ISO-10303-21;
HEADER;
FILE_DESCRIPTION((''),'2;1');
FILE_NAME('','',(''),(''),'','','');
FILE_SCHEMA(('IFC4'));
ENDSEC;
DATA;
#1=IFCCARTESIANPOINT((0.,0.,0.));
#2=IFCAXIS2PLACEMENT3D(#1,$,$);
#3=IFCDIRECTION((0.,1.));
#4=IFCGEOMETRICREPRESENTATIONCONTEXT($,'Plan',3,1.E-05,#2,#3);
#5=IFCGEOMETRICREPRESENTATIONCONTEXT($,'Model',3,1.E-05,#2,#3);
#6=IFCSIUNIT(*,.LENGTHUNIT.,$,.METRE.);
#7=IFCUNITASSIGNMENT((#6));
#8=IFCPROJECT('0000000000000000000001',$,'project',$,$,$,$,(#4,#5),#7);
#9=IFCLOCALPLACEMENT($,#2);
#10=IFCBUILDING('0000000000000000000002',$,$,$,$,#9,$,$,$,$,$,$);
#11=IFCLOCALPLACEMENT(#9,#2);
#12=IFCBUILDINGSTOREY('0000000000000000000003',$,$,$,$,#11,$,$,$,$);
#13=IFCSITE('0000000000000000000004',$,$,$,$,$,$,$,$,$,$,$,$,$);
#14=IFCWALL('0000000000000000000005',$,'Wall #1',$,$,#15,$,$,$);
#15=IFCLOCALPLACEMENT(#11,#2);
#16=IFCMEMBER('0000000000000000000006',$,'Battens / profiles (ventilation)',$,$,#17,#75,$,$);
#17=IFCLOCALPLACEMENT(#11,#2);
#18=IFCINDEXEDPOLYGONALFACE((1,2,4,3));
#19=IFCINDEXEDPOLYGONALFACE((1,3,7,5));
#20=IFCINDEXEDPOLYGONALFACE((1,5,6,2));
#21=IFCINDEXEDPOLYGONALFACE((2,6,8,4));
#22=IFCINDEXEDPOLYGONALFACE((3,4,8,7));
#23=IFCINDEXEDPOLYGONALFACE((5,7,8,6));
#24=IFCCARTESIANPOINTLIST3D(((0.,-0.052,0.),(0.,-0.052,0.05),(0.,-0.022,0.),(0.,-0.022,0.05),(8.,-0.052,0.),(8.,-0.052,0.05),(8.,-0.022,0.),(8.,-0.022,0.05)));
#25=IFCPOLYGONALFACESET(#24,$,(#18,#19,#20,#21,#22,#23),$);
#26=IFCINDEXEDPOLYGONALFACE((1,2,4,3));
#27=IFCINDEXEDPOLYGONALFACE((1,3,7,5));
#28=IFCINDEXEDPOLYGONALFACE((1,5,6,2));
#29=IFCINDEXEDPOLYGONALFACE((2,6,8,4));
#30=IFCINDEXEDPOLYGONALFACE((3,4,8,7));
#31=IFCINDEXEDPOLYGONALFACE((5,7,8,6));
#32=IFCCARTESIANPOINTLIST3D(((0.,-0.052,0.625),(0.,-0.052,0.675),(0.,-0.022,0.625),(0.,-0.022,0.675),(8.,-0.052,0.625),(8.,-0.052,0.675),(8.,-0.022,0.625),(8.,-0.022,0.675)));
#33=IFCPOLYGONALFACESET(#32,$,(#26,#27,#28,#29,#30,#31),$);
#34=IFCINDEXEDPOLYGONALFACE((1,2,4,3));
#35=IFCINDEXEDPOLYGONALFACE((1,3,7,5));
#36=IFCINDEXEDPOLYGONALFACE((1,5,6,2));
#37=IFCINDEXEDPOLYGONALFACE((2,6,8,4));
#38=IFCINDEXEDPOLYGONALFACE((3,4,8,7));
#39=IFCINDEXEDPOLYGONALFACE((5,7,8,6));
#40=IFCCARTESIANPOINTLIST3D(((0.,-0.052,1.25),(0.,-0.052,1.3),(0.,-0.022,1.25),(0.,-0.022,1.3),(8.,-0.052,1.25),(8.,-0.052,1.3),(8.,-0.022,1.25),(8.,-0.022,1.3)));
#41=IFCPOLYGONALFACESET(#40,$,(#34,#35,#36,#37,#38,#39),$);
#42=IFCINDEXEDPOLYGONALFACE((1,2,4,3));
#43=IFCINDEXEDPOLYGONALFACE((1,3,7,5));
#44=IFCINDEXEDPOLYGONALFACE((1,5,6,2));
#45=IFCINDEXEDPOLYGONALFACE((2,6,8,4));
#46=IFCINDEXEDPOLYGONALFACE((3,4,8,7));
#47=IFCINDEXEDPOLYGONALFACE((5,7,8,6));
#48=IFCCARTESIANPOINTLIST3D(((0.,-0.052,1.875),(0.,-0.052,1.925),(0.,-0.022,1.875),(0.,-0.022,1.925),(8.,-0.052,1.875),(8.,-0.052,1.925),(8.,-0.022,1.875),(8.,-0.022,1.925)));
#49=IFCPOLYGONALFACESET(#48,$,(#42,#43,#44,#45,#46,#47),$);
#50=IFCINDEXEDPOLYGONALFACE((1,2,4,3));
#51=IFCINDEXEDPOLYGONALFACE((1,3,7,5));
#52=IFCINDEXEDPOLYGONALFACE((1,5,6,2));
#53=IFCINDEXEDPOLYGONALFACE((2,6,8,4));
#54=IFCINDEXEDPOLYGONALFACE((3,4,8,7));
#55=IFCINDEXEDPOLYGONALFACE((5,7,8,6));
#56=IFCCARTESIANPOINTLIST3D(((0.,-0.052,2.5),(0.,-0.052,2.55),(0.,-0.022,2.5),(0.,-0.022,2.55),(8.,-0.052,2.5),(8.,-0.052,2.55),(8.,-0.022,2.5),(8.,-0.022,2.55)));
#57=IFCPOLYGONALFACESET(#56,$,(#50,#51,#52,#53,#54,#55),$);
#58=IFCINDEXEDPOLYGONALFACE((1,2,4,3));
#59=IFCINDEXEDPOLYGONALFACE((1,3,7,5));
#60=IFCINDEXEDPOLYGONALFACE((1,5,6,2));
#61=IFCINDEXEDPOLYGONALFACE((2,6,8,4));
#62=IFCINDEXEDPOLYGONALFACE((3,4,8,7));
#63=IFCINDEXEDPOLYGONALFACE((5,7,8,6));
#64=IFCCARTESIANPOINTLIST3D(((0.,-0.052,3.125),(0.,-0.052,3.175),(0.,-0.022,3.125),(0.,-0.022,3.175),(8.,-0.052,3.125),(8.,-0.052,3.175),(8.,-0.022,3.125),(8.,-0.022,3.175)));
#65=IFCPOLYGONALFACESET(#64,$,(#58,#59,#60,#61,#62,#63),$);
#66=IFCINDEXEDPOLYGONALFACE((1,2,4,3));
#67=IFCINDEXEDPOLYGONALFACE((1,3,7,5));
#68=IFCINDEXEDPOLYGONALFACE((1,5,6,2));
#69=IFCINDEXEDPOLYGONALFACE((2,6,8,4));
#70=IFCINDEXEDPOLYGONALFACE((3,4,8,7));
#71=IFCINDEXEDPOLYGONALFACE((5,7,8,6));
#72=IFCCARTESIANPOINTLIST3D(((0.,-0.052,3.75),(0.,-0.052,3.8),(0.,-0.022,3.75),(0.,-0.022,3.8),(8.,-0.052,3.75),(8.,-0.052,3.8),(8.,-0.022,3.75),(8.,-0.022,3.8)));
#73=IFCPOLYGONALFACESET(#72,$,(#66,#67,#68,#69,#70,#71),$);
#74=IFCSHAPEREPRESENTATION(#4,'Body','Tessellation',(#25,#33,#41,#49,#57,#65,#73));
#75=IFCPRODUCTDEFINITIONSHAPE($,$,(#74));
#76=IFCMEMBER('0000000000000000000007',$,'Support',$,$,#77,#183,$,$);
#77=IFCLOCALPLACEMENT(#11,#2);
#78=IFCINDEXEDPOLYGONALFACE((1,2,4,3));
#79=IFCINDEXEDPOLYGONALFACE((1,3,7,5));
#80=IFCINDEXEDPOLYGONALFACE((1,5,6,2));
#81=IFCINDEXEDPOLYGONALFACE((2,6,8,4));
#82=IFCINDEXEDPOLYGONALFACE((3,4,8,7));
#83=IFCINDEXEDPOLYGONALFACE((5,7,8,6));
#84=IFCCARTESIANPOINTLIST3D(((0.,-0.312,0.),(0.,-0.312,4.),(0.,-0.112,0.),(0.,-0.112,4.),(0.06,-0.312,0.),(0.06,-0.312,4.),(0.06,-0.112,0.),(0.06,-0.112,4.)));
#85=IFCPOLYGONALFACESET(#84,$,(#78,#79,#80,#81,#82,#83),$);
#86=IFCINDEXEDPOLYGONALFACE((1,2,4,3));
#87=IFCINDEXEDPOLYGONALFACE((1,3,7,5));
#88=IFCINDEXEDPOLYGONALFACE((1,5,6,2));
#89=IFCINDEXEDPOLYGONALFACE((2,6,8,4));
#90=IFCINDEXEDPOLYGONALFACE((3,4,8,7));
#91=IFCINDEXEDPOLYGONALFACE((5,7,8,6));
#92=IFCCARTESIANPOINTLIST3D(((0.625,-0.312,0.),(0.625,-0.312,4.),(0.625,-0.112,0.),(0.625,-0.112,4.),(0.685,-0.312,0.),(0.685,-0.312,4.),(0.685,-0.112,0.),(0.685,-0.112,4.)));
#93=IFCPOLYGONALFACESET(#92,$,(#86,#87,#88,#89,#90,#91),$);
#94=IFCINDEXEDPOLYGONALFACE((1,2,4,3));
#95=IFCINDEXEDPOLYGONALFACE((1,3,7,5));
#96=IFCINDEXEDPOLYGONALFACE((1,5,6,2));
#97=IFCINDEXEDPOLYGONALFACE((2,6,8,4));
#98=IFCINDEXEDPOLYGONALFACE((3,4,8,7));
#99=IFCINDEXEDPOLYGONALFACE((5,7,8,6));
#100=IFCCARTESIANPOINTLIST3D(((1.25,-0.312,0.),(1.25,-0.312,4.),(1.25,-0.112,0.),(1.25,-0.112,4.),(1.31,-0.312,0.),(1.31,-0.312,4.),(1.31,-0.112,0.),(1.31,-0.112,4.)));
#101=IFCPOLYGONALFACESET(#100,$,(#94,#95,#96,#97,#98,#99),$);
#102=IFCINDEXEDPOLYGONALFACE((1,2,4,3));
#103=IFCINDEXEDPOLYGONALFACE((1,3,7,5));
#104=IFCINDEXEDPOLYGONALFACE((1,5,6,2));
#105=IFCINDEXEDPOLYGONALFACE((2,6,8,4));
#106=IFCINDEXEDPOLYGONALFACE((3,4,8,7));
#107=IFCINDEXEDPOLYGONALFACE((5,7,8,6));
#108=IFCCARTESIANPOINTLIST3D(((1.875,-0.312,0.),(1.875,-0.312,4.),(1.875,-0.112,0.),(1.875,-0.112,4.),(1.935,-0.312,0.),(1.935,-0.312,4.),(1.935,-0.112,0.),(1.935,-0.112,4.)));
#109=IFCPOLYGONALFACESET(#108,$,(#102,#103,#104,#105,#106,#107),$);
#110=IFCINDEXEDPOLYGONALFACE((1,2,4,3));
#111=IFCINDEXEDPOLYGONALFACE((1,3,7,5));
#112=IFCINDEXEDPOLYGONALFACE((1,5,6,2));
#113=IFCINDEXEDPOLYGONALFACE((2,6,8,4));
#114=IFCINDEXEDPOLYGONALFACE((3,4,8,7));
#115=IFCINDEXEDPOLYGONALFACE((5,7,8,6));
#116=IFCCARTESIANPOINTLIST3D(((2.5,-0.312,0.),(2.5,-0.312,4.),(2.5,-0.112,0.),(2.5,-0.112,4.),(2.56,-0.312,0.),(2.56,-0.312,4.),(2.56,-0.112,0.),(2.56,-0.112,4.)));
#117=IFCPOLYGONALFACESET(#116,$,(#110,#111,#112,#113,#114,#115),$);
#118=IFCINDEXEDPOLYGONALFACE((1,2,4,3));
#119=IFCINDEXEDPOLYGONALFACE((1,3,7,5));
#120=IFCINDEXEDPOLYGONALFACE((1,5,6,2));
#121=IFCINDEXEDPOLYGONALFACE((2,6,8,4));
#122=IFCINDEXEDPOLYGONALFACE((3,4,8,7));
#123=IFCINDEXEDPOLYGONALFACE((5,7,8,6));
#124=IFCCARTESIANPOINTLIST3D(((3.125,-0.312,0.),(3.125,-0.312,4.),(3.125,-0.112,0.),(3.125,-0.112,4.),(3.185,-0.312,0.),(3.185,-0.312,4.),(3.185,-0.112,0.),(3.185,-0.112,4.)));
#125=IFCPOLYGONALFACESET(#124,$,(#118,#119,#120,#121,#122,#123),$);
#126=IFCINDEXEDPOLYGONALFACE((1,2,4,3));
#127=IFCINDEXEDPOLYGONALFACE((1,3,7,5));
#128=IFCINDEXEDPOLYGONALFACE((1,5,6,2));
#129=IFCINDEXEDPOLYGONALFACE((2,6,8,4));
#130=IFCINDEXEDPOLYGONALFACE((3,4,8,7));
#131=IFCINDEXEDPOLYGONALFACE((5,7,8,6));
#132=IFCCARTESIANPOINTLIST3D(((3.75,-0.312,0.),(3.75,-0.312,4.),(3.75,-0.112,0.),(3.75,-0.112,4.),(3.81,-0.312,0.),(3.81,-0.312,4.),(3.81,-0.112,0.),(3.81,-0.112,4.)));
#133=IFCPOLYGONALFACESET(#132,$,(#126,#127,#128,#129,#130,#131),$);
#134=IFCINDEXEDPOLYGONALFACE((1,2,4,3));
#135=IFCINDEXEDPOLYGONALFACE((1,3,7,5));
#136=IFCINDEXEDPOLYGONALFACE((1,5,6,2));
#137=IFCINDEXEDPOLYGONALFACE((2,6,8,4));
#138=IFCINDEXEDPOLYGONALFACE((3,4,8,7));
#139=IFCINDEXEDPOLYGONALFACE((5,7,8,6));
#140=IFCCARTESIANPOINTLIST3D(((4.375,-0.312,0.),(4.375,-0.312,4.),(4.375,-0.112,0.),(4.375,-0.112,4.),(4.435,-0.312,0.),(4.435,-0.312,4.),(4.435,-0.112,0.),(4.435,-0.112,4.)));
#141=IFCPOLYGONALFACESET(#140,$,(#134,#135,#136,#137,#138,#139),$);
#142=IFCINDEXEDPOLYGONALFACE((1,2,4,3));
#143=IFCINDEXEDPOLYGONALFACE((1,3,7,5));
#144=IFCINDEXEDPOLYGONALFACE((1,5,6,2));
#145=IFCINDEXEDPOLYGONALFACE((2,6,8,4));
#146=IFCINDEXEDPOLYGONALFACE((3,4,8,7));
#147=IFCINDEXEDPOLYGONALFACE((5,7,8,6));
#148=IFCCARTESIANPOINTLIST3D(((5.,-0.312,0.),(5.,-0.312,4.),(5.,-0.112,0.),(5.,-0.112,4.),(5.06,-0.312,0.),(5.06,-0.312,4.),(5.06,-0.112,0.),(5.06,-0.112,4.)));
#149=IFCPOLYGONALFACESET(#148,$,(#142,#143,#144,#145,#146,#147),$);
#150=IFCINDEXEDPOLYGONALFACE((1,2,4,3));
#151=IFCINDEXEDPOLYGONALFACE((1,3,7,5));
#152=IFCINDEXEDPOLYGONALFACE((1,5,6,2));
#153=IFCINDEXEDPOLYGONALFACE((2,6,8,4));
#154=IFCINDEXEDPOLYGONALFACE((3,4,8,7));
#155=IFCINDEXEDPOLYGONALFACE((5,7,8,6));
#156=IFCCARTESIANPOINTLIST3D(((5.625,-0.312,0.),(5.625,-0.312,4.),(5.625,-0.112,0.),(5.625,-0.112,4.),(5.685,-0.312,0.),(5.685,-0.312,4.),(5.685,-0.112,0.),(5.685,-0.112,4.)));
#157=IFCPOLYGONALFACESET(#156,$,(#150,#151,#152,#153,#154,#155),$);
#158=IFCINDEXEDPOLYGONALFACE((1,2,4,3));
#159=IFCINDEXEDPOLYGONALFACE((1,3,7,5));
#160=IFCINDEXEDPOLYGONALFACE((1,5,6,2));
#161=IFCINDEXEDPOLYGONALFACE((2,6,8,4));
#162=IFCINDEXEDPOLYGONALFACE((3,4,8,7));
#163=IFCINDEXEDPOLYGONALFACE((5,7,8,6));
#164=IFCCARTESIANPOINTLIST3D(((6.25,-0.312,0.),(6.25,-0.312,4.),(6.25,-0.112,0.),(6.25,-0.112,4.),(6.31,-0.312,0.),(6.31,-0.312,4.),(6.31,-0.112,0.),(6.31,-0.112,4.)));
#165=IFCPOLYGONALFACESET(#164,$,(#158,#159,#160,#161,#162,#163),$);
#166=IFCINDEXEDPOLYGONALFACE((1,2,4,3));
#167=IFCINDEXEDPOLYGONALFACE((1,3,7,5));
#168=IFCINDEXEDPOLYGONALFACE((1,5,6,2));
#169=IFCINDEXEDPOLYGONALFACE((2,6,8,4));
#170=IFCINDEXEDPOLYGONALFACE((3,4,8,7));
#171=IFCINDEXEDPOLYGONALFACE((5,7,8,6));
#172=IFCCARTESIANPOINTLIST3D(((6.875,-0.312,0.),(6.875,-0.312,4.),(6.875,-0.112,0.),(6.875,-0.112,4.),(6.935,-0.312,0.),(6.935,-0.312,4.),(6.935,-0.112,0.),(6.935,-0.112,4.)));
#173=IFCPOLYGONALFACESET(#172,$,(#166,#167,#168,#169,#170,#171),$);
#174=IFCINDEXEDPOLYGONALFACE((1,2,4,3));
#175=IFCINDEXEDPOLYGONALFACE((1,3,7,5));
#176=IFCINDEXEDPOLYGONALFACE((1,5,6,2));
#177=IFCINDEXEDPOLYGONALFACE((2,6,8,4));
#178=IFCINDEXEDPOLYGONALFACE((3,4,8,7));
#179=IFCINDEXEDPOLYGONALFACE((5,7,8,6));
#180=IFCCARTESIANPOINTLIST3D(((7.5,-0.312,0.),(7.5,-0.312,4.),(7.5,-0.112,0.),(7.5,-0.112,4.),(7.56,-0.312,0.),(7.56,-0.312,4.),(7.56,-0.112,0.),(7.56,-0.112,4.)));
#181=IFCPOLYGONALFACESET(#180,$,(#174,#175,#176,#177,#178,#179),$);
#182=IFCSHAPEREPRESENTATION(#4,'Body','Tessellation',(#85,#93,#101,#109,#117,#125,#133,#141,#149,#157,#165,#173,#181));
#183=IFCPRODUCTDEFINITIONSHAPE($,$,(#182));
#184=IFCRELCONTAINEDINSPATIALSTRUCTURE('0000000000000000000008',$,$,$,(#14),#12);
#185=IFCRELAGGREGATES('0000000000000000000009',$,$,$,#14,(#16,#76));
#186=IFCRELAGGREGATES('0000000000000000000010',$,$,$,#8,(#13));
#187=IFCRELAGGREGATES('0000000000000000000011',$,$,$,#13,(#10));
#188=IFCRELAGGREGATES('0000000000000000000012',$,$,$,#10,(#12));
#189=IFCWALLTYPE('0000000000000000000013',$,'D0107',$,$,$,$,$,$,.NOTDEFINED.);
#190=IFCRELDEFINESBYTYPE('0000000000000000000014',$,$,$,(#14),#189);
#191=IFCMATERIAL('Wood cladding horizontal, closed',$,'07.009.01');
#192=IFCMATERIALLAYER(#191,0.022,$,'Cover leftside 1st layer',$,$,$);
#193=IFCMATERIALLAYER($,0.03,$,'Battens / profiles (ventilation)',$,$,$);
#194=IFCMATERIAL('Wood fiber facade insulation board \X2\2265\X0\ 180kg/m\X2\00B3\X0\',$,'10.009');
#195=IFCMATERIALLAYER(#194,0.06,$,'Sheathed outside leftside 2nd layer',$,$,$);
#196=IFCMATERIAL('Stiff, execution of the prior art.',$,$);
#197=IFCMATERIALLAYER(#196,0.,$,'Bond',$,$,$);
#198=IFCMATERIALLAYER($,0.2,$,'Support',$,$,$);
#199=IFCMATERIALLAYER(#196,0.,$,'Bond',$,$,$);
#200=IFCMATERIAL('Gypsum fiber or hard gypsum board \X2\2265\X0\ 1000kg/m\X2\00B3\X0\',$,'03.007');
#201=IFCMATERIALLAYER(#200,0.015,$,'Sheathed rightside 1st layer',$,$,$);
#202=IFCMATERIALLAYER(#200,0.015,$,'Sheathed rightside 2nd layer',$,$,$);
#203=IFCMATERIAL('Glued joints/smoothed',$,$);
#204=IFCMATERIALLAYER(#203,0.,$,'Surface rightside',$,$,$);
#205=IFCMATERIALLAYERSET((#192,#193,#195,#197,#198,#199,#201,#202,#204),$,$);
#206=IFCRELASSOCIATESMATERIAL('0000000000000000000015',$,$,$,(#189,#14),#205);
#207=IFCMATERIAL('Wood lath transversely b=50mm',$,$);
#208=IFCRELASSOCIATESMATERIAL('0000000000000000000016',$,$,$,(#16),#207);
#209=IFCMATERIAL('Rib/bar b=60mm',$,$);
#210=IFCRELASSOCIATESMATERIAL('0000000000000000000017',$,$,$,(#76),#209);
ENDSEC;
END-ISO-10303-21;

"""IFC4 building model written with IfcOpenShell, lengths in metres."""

from ifc_helpers import new_model, si_unit, direction, frame, frame_2d, origin, place, context, project, spatial, rectangle, extrude, material, layer, layer_set, type_object, element, aggregate, save


model = new_model("IFC4")

# Units and contexts
plan_context = context("Plan", 3, precision=1e-05, world=origin(), true_north=direction((0.0, 1.0)))
model_context = context("Model", 3, precision=1e-05, world=origin(), true_north=direction((0.0, 1.0)))
ifc_project = project(units=[si_unit("LENGTHUNIT", "METRE")], contexts=[plan_context, model_context])

# Site, building, storey
site = spatial("IfcSite", under=ifc_project)
building_placement = place(None, origin())
building = spatial("IfcBuilding", under=site, at=building_placement)
storey_placement = place(building_placement, origin())
storey = spatial("IfcBuildingStorey", under=building, at=storey_placement)

# Wall, members
ifc_material_1 = material(Name="Wood cladding horizontal, closed", Category="07.009.01")
ifc_layer_1 = layer(ifc_material_1, 0.022, Name="Cover leftside 1st layer")
ifc_layer_2 = layer(None, 0.03, Name="Battens / profiles (ventilation)")
ifc_material_2 = material(Name="Wood fiber facade insulation board ≥ 180kg/m³", Category="10.009")
ifc_layer_3 = layer(ifc_material_2, 0.06, Name="Sheathed outside leftside 2nd layer")
ifc_material_3 = material(Name="Stiff, execution of the prior art.")
ifc_layer_4 = layer(ifc_material_3, 0.0, Name="Bond")
ifc_layer_5 = layer(None, 0.2, Name="Support")
ifc_layer_6 = layer(ifc_material_3, 0.0, Name="Bond")
ifc_material_4 = material(Name="Gypsum fiber or hard gypsum board ≥ 1000kg/m³", Category="03.007")
ifc_layer_7 = layer(ifc_material_4, 0.015, Name="Sheathed rightside 1st layer")
ifc_layer_8 = layer(ifc_material_4, 0.015, Name="Sheathed rightside 2nd layer")
ifc_material_5 = material(Name="Glued joints/smoothed")
ifc_layer_9 = layer(ifc_material_5, 0.0, Name="Surface rightside")
ifc_layer_set = layer_set([ifc_layer_1, ifc_layer_2, ifc_layer_3, ifc_layer_4, ifc_layer_5, ifc_layer_6, ifc_layer_7, ifc_layer_8, ifc_layer_9])
wall_type = type_object("IfcWallType", Name="D0107", PredefinedType="NOTDEFINED", material=ifc_layer_set)
wall_placement = place(None, frame((0.0, 0.0, 0.0), z_axis=(0.0, -1.0, 0.0), x_axis=(1.0, 0.0, 0.0)))
wall = element("IfcWall", 1, at=wall_placement, inside=storey, type_object=wall_type, material=ifc_layer_set, Name="Wall #1")
ifc_material_6 = material(Name="Wood lath transversely b=50mm")
member_1_placement = place(wall_placement, origin())
member_1 = element("IfcMember", 2, at=member_1_placement, material=ifc_material_6, Name="Battens / profiles (ventilation)", context=plan_context, shape_type="SweptSolid", body=[
    extrude(rectangle(XDim=0.05, YDim=0.03, at=frame_2d((0.025, 0.015), x_axis=(1.0, 0.0))), frame((0.0, 0.0, 0.022), z_axis=(1.0, 0.0, 0.0), x_axis=(0.0, 1.0, 0.0)), (0.0, 0.0, 1.0), 8.0),
    extrude(rectangle(XDim=0.05, YDim=0.03, at=frame_2d((0.025, 0.015), x_axis=(1.0, 0.0))), frame((0.0, 0.625, 0.022), z_axis=(1.0, 0.0, 0.0), x_axis=(0.0, 1.0, 0.0)), (0.0, 0.0, 1.0), 8.0),
    extrude(rectangle(XDim=0.05, YDim=0.03, at=frame_2d((0.025, 0.015), x_axis=(1.0, 0.0))), frame((0.0, 1.25, 0.022), z_axis=(1.0, 0.0, 0.0), x_axis=(0.0, 1.0, 0.0)), (0.0, 0.0, 1.0), 8.0),
    extrude(rectangle(XDim=0.05, YDim=0.03, at=frame_2d((0.025, 0.015), x_axis=(1.0, 0.0))), frame((0.0, 1.875, 0.022), z_axis=(1.0, 0.0, 0.0), x_axis=(0.0, 1.0, 0.0)), (0.0, 0.0, 1.0), 8.0),
    extrude(rectangle(XDim=0.05, YDim=0.03, at=frame_2d((0.025, 0.015), x_axis=(1.0, 0.0))), frame((0.0, 2.5, 0.022), z_axis=(1.0, 0.0, 0.0), x_axis=(0.0, 1.0, 0.0)), (0.0, 0.0, 1.0), 8.0),
    extrude(rectangle(XDim=0.05, YDim=0.03, at=frame_2d((0.025, 0.015), x_axis=(1.0, 0.0))), frame((0.0, 3.125, 0.022), z_axis=(1.0, 0.0, 0.0), x_axis=(0.0, 1.0, 0.0)), (0.0, 0.0, 1.0), 8.0),
    extrude(rectangle(XDim=0.05, YDim=0.03, at=frame_2d((0.025, 0.015), x_axis=(1.0, 0.0))), frame((0.0, 3.75, 0.022), z_axis=(1.0, 0.0, 0.0), x_axis=(0.0, 1.0, 0.0)), (0.0, 0.0, 1.0), 8.0),
])
ifc_material_7 = material(Name="Rib/bar b=60mm")
member_2_placement = place(wall_placement, origin())
member_2 = element("IfcMember", 3, at=member_2_placement, material=ifc_material_7, Name="Support", context=plan_context, shape_type="SweptSolid", body=[
    extrude(rectangle(XDim=0.06, YDim=0.2, at=frame_2d((0.03, 0.1), x_axis=(1.0, 0.0))), frame((0.0, 4.0, 0.112), z_axis=(0.0, -1.0, 0.0), x_axis=(1.0, 0.0, 0.0)), (0.0, 0.0, 1.0), 4.0),
    extrude(rectangle(XDim=0.06, YDim=0.2, at=frame_2d((0.03, 0.1), x_axis=(1.0, 0.0))), frame((0.625, 4.0, 0.112), z_axis=(0.0, -1.0, 0.0), x_axis=(1.0, 0.0, 0.0)), (0.0, 0.0, 1.0), 4.0),
    extrude(rectangle(XDim=0.06, YDim=0.2, at=frame_2d((0.03, 0.1), x_axis=(1.0, 0.0))), frame((1.25, 4.0, 0.112), z_axis=(0.0, -1.0, 0.0), x_axis=(1.0, 0.0, 0.0)), (0.0, 0.0, 1.0), 4.0),
    extrude(rectangle(XDim=0.06, YDim=0.2, at=frame_2d((0.03, 0.1), x_axis=(1.0, 0.0))), frame((1.875, 4.0, 0.112), z_axis=(0.0, -1.0, 0.0), x_axis=(1.0, 0.0, 0.0)), (0.0, 0.0, 1.0), 4.0),
    extrude(rectangle(XDim=0.06, YDim=0.2, at=frame_2d((0.03, 0.1), x_axis=(1.0, 0.0))), frame((2.5, 4.0, 0.112), z_axis=(0.0, -1.0, 0.0), x_axis=(1.0, 0.0, 0.0)), (0.0, 0.0, 1.0), 4.0),
    extrude(rectangle(XDim=0.06, YDim=0.2, at=frame_2d((0.03, 0.1), x_axis=(1.0, 0.0))), frame((3.125, 4.0, 0.112), z_axis=(0.0, -1.0, 0.0), x_axis=(1.0, 0.0, 0.0)), (0.0, 0.0, 1.0), 4.0),
    extrude(rectangle(XDim=0.06, YDim=0.2, at=frame_2d((0.03, 0.1), x_axis=(1.0, 0.0))), frame((3.75, 4.0, 0.112), z_axis=(0.0, -1.0, 0.0), x_axis=(1.0, 0.0, 0.0)), (0.0, 0.0, 1.0), 4.0),
    extrude(rectangle(XDim=0.06, YDim=0.2, at=frame_2d((0.03, 0.1), x_axis=(1.0, 0.0))), frame((4.375, 4.0, 0.112), z_axis=(0.0, -1.0, 0.0), x_axis=(1.0, 0.0, 0.0)), (0.0, 0.0, 1.0), 4.0),
    extrude(rectangle(XDim=0.06, YDim=0.2, at=frame_2d((0.03, 0.1), x_axis=(1.0, 0.0))), frame((5.0, 4.0, 0.112), z_axis=(0.0, -1.0, 0.0), x_axis=(1.0, 0.0, 0.0)), (0.0, 0.0, 1.0), 4.0),
    extrude(rectangle(XDim=0.06, YDim=0.2, at=frame_2d((0.03, 0.1), x_axis=(1.0, 0.0))), frame((5.625, 4.0, 0.112), z_axis=(0.0, -1.0, 0.0), x_axis=(1.0, 0.0, 0.0)), (0.0, 0.0, 1.0), 4.0),
    extrude(rectangle(XDim=0.06, YDim=0.2, at=frame_2d((0.03, 0.1), x_axis=(1.0, 0.0))), frame((6.25, 4.0, 0.112), z_axis=(0.0, -1.0, 0.0), x_axis=(1.0, 0.0, 0.0)), (0.0, 0.0, 1.0), 4.0),
    extrude(rectangle(XDim=0.06, YDim=0.2, at=frame_2d((0.03, 0.1), x_axis=(1.0, 0.0))), frame((6.875, 4.0, 0.112), z_axis=(0.0, -1.0, 0.0), x_axis=(1.0, 0.0, 0.0)), (0.0, 0.0, 1.0), 4.0),
    extrude(rectangle(XDim=0.06, YDim=0.2, at=frame_2d((0.03, 0.1), x_axis=(1.0, 0.0))), frame((7.5, 4.0, 0.112), z_axis=(0.0, -1.0, 0.0), x_axis=(1.0, 0.0, 0.0)), (0.0, 0.0, 1.0), 4.0),
])
aggregate(wall, [member_1, member_2])

save(model, "model.ifc")
